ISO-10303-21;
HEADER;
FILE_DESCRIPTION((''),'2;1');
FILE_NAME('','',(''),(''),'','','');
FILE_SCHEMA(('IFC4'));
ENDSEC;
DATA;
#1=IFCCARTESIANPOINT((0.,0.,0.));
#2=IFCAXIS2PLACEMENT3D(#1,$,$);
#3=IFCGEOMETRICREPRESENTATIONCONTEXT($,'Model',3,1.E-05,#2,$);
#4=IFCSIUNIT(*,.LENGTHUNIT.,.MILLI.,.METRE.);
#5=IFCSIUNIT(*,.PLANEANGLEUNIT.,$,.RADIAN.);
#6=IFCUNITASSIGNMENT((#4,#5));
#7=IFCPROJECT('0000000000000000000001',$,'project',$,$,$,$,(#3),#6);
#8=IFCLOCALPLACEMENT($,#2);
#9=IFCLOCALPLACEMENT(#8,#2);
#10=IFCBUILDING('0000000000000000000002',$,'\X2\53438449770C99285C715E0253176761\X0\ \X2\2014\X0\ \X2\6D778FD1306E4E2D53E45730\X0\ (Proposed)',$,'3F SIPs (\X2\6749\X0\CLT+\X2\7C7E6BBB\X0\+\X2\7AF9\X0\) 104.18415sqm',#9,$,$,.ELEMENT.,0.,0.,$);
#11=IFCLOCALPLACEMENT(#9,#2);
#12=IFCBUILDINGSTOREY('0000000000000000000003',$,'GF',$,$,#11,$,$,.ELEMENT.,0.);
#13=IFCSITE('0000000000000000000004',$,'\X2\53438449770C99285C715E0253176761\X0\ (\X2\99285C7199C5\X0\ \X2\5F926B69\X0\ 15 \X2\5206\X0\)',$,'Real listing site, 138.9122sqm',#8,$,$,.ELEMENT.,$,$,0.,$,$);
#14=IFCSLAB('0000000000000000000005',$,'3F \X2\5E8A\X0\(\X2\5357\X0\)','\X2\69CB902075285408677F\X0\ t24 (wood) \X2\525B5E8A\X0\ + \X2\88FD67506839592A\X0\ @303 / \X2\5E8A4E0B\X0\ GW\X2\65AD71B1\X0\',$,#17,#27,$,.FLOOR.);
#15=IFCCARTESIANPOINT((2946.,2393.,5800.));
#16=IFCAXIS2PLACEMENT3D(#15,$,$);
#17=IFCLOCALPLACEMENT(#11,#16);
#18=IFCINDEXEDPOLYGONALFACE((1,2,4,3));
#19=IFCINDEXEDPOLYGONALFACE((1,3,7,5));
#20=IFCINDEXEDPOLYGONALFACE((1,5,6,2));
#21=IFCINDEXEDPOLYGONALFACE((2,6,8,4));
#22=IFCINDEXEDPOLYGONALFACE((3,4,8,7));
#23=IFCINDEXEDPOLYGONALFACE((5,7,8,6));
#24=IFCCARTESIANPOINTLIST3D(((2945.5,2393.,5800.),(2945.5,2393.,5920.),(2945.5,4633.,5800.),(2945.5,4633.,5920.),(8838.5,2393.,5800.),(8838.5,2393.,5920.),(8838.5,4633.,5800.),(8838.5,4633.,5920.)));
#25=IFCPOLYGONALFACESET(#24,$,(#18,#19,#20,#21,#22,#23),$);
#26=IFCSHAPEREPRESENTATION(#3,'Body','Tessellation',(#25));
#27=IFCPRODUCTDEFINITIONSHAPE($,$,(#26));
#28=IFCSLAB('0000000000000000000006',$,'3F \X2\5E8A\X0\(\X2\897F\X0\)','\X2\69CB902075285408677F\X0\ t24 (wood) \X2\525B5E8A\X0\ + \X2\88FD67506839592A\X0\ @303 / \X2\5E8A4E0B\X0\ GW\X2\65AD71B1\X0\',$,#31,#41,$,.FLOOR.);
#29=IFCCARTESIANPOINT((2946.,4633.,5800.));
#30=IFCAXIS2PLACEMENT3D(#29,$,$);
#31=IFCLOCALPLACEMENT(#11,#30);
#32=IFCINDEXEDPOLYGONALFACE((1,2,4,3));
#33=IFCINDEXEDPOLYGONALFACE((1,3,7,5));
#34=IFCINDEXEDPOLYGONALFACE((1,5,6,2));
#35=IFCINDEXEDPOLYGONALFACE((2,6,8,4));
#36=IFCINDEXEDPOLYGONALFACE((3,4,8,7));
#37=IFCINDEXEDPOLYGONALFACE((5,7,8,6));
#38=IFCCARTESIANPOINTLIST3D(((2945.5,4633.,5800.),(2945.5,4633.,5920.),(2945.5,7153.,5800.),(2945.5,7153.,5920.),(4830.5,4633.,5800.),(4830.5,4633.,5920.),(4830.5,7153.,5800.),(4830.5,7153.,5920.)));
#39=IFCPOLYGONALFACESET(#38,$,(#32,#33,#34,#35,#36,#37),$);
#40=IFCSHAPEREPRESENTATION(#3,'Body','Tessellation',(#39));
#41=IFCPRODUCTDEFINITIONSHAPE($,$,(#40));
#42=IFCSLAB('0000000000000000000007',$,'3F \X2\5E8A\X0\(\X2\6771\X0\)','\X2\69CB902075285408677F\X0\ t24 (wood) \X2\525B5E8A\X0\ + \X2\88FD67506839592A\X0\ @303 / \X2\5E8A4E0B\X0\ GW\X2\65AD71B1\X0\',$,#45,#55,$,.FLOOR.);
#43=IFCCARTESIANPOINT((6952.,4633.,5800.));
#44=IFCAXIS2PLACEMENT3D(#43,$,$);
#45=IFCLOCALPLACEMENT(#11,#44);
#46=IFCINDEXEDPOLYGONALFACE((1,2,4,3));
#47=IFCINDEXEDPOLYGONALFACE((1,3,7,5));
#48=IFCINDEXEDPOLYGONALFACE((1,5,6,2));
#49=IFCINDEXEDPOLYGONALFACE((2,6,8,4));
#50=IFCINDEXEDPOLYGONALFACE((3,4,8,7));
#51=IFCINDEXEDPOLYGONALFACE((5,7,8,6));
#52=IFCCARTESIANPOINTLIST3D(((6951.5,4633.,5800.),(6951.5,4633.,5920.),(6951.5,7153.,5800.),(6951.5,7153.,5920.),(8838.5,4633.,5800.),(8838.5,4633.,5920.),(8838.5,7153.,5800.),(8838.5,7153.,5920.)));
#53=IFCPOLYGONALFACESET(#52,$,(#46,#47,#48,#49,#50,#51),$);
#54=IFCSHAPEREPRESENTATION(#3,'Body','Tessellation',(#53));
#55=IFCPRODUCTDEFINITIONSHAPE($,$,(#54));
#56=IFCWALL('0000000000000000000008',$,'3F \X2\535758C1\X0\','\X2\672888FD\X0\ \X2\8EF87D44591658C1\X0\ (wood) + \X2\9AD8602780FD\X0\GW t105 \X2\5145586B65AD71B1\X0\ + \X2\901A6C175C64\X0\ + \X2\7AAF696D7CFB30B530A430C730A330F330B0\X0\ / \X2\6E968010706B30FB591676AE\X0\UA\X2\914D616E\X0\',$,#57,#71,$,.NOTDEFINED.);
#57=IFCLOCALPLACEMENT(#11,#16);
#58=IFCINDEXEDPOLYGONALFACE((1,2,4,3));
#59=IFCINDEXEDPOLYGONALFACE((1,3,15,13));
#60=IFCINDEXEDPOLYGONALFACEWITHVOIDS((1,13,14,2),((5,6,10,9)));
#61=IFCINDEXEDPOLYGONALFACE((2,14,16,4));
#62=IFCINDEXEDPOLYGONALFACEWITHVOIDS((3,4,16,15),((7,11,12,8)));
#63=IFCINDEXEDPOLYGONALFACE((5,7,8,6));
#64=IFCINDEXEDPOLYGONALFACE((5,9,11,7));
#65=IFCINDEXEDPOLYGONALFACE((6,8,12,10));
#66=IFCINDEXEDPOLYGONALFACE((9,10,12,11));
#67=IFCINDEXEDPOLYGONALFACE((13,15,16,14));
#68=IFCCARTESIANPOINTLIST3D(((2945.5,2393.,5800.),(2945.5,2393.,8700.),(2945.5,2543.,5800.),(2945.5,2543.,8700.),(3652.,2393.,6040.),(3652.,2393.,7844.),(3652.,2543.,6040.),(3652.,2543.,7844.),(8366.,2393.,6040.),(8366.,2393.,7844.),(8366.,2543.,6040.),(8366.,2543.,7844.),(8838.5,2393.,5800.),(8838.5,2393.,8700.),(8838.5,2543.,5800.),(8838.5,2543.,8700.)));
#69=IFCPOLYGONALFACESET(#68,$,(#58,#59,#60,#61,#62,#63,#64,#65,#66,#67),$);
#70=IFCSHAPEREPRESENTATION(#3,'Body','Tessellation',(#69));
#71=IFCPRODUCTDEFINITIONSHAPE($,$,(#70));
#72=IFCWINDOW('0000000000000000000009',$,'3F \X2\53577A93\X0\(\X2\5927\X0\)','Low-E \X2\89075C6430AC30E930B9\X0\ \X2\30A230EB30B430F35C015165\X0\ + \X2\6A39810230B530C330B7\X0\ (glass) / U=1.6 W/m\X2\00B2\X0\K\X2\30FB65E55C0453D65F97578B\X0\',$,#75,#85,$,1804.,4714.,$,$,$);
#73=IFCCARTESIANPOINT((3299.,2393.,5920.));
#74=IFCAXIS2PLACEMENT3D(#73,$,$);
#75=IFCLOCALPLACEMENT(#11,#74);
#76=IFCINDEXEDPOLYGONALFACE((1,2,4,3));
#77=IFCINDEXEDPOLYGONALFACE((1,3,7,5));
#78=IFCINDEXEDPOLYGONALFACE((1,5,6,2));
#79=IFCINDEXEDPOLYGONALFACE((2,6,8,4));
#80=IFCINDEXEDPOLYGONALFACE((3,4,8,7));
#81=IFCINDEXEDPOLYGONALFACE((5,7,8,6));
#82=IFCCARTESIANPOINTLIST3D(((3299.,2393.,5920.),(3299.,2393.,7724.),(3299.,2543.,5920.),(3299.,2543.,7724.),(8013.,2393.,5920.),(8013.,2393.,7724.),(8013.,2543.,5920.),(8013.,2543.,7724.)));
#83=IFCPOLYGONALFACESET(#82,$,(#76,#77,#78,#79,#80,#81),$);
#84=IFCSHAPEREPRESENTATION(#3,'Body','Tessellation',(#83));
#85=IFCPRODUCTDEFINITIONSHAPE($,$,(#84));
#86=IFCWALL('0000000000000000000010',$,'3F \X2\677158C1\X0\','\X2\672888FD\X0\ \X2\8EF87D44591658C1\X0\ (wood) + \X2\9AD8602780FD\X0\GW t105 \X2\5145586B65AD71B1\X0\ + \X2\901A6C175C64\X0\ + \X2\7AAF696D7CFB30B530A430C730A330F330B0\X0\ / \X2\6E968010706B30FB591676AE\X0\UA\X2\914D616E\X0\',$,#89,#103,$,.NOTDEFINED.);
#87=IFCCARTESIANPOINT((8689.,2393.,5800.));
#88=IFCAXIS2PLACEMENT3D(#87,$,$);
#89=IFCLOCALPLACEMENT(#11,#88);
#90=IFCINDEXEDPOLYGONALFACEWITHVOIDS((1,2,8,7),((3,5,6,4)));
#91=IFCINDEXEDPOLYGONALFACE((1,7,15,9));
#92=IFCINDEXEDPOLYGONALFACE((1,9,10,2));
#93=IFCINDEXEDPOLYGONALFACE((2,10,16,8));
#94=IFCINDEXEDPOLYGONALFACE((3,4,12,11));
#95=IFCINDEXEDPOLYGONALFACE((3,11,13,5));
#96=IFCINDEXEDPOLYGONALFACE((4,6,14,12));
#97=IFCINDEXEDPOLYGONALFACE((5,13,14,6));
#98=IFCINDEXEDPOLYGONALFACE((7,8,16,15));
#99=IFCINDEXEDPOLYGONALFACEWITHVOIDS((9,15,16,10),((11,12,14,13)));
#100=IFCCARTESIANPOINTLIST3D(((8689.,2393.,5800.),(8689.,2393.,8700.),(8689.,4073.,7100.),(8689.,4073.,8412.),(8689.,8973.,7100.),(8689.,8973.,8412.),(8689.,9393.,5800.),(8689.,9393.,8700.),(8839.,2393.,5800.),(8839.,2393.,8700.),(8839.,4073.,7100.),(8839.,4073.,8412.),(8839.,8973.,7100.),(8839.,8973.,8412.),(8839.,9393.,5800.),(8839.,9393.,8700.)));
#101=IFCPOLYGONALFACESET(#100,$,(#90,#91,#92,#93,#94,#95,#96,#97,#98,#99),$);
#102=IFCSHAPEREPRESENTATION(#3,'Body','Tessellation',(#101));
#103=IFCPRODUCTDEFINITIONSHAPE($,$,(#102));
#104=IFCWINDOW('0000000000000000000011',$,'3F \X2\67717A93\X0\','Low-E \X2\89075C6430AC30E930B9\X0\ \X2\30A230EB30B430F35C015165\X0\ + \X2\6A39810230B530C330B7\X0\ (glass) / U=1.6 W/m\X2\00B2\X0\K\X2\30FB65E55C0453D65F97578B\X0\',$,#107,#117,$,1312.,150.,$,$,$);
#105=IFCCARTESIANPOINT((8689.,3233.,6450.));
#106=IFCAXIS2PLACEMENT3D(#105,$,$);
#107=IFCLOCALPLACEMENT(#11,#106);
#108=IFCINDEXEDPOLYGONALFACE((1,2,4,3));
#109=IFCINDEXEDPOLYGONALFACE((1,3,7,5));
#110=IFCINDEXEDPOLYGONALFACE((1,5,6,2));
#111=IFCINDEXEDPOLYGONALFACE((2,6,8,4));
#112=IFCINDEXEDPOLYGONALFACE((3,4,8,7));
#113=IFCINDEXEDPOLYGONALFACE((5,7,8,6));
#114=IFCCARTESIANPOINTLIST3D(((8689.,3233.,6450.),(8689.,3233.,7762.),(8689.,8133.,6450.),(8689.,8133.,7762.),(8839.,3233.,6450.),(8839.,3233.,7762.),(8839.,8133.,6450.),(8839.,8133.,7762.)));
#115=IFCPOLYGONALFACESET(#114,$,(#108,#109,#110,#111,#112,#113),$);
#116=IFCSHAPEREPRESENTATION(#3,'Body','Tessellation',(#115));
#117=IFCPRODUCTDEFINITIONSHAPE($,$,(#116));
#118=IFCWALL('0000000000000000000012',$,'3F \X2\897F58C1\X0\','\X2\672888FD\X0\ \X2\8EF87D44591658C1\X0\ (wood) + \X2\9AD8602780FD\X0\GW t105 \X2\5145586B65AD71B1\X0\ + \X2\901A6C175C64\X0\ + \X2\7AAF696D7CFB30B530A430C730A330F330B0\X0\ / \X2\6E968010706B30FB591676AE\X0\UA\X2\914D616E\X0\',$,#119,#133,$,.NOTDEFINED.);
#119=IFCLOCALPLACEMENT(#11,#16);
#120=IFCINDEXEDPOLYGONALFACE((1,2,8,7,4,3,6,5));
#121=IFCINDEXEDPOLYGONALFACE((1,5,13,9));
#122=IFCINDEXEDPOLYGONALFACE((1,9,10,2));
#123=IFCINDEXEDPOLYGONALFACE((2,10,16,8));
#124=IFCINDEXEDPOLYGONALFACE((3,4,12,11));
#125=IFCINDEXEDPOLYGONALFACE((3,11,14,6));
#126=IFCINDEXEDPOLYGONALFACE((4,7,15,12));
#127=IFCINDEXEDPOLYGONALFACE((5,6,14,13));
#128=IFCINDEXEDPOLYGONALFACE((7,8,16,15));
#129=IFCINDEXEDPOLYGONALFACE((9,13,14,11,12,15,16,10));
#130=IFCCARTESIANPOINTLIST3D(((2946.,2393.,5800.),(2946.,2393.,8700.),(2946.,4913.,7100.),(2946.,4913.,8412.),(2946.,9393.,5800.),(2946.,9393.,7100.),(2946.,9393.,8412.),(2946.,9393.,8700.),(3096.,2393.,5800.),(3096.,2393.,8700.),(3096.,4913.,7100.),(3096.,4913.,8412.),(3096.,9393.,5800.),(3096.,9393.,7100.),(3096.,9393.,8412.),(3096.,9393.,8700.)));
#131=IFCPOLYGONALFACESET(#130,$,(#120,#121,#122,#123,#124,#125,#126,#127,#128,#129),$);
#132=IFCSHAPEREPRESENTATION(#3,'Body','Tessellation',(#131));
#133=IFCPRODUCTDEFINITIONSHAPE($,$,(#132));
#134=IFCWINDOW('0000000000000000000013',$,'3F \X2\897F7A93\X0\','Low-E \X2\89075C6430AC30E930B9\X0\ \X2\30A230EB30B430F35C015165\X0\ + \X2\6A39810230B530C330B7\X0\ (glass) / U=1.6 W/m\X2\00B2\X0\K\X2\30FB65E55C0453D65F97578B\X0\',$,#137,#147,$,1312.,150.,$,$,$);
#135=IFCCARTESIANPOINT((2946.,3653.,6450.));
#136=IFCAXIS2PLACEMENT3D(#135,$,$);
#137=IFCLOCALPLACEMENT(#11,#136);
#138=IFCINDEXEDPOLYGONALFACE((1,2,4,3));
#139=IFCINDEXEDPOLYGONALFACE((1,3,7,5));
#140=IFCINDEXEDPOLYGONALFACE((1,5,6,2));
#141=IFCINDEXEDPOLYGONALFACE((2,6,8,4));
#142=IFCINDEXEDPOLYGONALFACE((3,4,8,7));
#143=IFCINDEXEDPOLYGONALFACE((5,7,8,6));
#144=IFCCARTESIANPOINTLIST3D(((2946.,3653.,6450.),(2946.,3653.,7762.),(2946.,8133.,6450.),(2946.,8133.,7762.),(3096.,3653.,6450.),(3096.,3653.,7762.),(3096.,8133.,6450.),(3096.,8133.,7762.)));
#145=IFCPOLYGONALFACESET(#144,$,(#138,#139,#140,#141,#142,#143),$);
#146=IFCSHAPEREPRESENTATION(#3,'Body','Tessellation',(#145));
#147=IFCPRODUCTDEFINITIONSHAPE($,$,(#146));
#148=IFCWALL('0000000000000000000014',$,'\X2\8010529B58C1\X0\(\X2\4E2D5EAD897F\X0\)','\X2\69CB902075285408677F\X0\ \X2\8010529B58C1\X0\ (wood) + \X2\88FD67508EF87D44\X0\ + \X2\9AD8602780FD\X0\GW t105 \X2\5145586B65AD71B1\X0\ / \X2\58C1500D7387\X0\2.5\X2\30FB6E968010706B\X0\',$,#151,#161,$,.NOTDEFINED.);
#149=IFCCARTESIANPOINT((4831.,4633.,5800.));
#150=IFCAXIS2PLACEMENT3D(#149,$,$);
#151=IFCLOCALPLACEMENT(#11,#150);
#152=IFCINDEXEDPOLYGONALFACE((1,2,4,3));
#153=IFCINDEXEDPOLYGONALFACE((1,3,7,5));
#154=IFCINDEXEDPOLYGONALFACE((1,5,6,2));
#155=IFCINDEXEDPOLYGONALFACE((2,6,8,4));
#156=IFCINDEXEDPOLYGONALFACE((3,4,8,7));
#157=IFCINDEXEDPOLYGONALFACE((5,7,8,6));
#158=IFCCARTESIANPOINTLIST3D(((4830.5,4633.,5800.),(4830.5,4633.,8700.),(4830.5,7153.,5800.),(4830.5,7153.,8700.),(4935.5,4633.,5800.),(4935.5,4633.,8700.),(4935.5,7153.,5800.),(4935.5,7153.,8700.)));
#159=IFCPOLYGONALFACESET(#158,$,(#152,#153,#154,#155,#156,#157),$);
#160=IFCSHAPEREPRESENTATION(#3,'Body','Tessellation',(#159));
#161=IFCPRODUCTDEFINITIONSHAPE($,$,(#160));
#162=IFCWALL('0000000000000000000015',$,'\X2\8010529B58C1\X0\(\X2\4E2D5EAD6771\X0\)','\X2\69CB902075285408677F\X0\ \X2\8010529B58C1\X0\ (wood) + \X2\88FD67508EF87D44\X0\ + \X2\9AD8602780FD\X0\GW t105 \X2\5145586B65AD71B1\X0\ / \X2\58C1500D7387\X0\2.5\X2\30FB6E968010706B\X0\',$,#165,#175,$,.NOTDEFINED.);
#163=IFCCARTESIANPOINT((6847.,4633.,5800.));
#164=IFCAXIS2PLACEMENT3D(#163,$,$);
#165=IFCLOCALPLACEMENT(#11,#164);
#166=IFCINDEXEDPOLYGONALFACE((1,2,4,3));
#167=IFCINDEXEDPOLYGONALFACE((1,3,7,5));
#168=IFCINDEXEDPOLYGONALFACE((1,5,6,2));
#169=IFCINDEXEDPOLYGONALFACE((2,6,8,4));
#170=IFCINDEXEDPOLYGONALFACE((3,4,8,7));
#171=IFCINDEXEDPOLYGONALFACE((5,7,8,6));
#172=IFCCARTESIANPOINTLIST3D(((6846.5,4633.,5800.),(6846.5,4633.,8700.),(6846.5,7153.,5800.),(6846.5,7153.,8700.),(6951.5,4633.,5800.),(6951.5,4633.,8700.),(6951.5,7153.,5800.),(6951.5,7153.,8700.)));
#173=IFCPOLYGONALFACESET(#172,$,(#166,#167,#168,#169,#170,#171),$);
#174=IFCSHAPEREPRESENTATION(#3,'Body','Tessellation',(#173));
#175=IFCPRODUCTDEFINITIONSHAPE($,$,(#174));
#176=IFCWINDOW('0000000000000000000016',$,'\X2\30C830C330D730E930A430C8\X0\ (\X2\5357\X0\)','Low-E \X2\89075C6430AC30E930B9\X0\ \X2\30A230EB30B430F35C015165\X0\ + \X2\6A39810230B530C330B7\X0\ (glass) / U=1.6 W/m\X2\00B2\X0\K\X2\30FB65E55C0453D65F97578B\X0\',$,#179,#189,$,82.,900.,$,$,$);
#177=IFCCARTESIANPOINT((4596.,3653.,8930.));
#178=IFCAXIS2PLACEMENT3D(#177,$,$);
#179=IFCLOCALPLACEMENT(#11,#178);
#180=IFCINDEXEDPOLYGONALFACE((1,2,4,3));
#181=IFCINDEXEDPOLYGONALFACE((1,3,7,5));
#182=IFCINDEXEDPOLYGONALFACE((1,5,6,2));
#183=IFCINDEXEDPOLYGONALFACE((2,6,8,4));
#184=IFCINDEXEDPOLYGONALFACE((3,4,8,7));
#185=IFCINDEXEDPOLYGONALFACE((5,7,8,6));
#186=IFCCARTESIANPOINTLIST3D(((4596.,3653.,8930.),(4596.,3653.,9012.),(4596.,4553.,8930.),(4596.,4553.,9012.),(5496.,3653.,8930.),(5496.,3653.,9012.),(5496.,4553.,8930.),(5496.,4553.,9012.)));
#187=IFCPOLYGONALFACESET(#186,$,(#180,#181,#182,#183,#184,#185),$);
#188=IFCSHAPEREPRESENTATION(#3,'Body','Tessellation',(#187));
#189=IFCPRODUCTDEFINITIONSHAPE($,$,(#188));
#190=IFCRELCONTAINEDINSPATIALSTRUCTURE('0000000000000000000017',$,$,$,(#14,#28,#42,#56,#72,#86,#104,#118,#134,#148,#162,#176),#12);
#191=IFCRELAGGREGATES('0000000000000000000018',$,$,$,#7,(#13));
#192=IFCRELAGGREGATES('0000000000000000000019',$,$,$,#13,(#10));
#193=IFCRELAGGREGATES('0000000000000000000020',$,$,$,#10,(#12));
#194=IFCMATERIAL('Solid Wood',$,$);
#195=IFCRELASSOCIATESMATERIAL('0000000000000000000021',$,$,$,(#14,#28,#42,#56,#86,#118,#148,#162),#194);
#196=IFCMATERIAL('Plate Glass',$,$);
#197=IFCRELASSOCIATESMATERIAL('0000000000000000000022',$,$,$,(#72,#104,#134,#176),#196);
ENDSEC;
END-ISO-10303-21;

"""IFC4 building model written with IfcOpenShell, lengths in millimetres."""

from ifc_helpers import new_model, si_unit, frame, frame_2d, origin, place, context, project, spatial, rectangle, extrude, material, element, fill, save


model = new_model("IFC4")

# Units and contexts
model_context = context("Model", 3, precision=1e-05, world=origin())
ifc_project = project(units=[si_unit("LENGTHUNIT", "METRE", prefix="MILLI"), si_unit("PLANEANGLEUNIT", "RADIAN")], contexts=[model_context])

# Site, building, storey
site_placement = place(None, origin())
site = spatial("IfcSite", under=ifc_project, at=site_placement, Name="千葉県館山市北条 (館山駅 徒歩 15 分)", ObjectType="Real listing site, 138.9122sqm", CompositionType="ELEMENT", RefElevation=0.0)
building_placement = place(site_placement, origin())
building = spatial("IfcBuilding", under=site, at=building_placement, Name="千葉県館山市北条 — 海近の中古地 (Proposed)", ObjectType="3F SIPs (杉CLT+籾殻+竹) 104.18415sqm", CompositionType="ELEMENT", ElevationOfRefHeight=0.0, ElevationOfTerrain=0.0)
storey_placement = place(building_placement, origin())
storey = spatial("IfcBuildingStorey", under=building, at=storey_placement, Name="GF", CompositionType="ELEMENT", Elevation=0.0)

# Slabs
ifc_material_1 = material(Name="Solid Wood")
slab_1_placement = place(storey_placement, frame((2946.0, 2393.0, 5800.0)))
element("IfcSlab", 1, at=slab_1_placement, inside=storey, material=ifc_material_1, Name="3F 床(南)", Description="構造用合板 t24 (wood) 剛床 + 製材根太 @303 / 床下 GW断熱", PredefinedType="FLOOR", context=model_context, shape_type="SweptSolid", body=[
    extrude(rectangle(XDim=5893.0, YDim=2240.0, at=frame_2d((2946.0, 1120.0))), frame((2946.0, 2393.0, 5800.0)), (0.0, 0.0, 1.0), 120.0),
])
slab_2_placement = place(storey_placement, frame((2946.0, 4633.0, 5800.0)))
element("IfcSlab", 2, at=slab_2_placement, inside=storey, material=ifc_material_1, Name="3F 床(西)", Description="構造用合板 t24 (wood) 剛床 + 製材根太 @303 / 床下 GW断熱", PredefinedType="FLOOR", context=model_context, shape_type="SweptSolid", body=[
    extrude(rectangle(XDim=1885.0, YDim=2520.0, at=frame_2d((942.0, 1260.0))), frame((2946.0, 4633.0, 5800.0)), (0.0, 0.0, 1.0), 120.0),
])
slab_3_placement = place(storey_placement, frame((6952.0, 4633.0, 5800.0)))
element("IfcSlab", 3, at=slab_3_placement, inside=storey, material=ifc_material_1, Name="3F 床(東)", Description="構造用合板 t24 (wood) 剛床 + 製材根太 @303 / 床下 GW断熱", PredefinedType="FLOOR", context=model_context, shape_type="SweptSolid", body=[
    extrude(rectangle(XDim=1887.0, YDim=2520.0, at=frame_2d((943.0, 1260.0))), frame((6952.0, 4633.0, 5800.0)), (0.0, 0.0, 1.0), 120.0),
])

# Walls, openings, windows
wall_1_placement = place(storey_placement, frame((2946.0, 2393.0, 5800.0)))
wall_1 = element("IfcWall", 4, at=wall_1_placement, inside=storey, material=ifc_material_1, Name="3F 南壁", Description="木製 軸組外壁 (wood) + 高性能GW t105 充填断熱 + 通気層 + 窯業系サイディング / 準耐火・外皮UA配慮", PredefinedType="NOTDEFINED", context=model_context, shape_type="SweptSolid", body=[
    extrude(rectangle(XDim=5893.0, YDim=150.0, at=frame_2d((2946.0, 75.0))), frame((2946.0, 2393.0, 5800.0)), (0.0, 0.0, 1.0), 2900.0),
])
opening_1_placement = place(storey_placement, frame((3299.0, 2393.0, 5920.0)))
opening_1 = element("IfcOpeningElement", 5, at=opening_1_placement, cuts=wall_1, PredefinedType="NOTDEFINED", context=model_context, shape_type="SweptSolid", body=[
    extrude(rectangle(XDim=4714.0, YDim=150.0, at=frame_2d((2357.0, 75.0))), frame((3299.0, 2393.0, 5920.0)), (0.0, 0.0, 1.0), 1804.0),
])
ifc_material_2 = material(Name="Plate Glass")
window_1_placement = place(storey_placement, frame((3299.0, 2393.0, 5920.0)))
window_1 = element("IfcWindow", 6, at=window_1_placement, inside=storey, material=ifc_material_2, Name="3F 南窓(大)", Description="Low-E 複層ガラス アルゴン封入 + 樹脂サッシ (glass) / U=1.6 W/m²K・日射取得型", OverallHeight=1804.0, OverallWidth=4714.0, context=model_context, shape_type="SweptSolid", body=[
    extrude(rectangle(XDim=4714.0, YDim=150.0, at=frame_2d((2357.0, 75.0))), frame((3299.0, 2393.0, 5920.0)), (0.0, 0.0, 1.0), 1804.0),
])
fill(opening_1, window_1)
wall_2_placement = place(storey_placement, frame((8689.0, 2393.0, 5800.0)))
wall_2 = element("IfcWall", 7, at=wall_2_placement, inside=storey, material=ifc_material_1, Name="3F 東壁", Description="木製 軸組外壁 (wood) + 高性能GW t105 充填断熱 + 通気層 + 窯業系サイディング / 準耐火・外皮UA配慮", PredefinedType="NOTDEFINED", context=model_context, shape_type="SweptSolid", body=[
    extrude(rectangle(XDim=150.0, YDim=7000.0, at=frame_2d((75.0, 3500.0))), frame((8689.0, 2393.0, 5800.0)), (0.0, 0.0, 1.0), 2900.0),
])
opening_2_placement = place(storey_placement, frame((8689.0, 3233.0, 6450.0)))
opening_2 = element("IfcOpeningElement", 8, at=opening_2_placement, cuts=wall_2, PredefinedType="NOTDEFINED", context=model_context, shape_type="SweptSolid", body=[
    extrude(rectangle(XDim=150.0, YDim=4900.0, at=frame_2d((75.0, 2450.0))), frame((8689.0, 3233.0, 6450.0)), (0.0, 0.0, 1.0), 1312.0),
])
window_2_placement = place(storey_placement, frame((8689.0, 3233.0, 6450.0)))
window_2 = element("IfcWindow", 9, at=window_2_placement, inside=storey, material=ifc_material_2, Name="3F 東窓", Description="Low-E 複層ガラス アルゴン封入 + 樹脂サッシ (glass) / U=1.6 W/m²K・日射取得型", OverallHeight=1312.0, OverallWidth=150.0, context=model_context, shape_type="SweptSolid", body=[
    extrude(rectangle(XDim=150.0, YDim=4900.0, at=frame_2d((75.0, 2450.0))), frame((8689.0, 3233.0, 6450.0)), (0.0, 0.0, 1.0), 1312.0),
])
fill(opening_2, window_2)
wall_3_placement = place(storey_placement, frame((2946.0, 2393.0, 5800.0)))
wall_3 = element("IfcWall", 10, at=wall_3_placement, inside=storey, material=ifc_material_1, Name="3F 西壁", Description="木製 軸組外壁 (wood) + 高性能GW t105 充填断熱 + 通気層 + 窯業系サイディング / 準耐火・外皮UA配慮", PredefinedType="NOTDEFINED", context=model_context, shape_type="SweptSolid", body=[
    extrude(rectangle(XDim=150.0, YDim=7000.0, at=frame_2d((75.0, 3500.0))), frame((2946.0, 2393.0, 5800.0)), (0.0, 0.0, 1.0), 2900.0),
])
opening_3_placement = place(storey_placement, frame((2946.0, 3653.0, 6450.0)))
opening_3 = element("IfcOpeningElement", 11, at=opening_3_placement, cuts=wall_3, PredefinedType="NOTDEFINED", context=model_context, shape_type="SweptSolid", body=[
    extrude(rectangle(XDim=150.0, YDim=4480.0, at=frame_2d((75.0, 2240.0))), frame((2946.0, 3653.0, 6450.0)), (0.0, 0.0, 1.0), 1312.0),
])
window_3_placement = place(storey_placement, frame((2946.0, 3653.0, 6450.0)))
window_3 = element("IfcWindow", 12, at=window_3_placement, inside=storey, material=ifc_material_2, Name="3F 西窓", Description="Low-E 複層ガラス アルゴン封入 + 樹脂サッシ (glass) / U=1.6 W/m²K・日射取得型", OverallHeight=1312.0, OverallWidth=150.0, context=model_context, shape_type="SweptSolid", body=[
    extrude(rectangle(XDim=150.0, YDim=4480.0, at=frame_2d((75.0, 2240.0))), frame((2946.0, 3653.0, 6450.0)), (0.0, 0.0, 1.0), 1312.0),
])
fill(opening_3, window_3)

# Walls
wall_4_placement = place(storey_placement, frame((4831.0, 4633.0, 5800.0)))
element("IfcWall", 13, at=wall_4_placement, inside=storey, material=ifc_material_1, Name="耐力壁(中庭西)", Description="構造用合板 耐力壁 (wood) + 製材軸組 + 高性能GW t105 充填断熱 / 壁倍率2.5・準耐火", PredefinedType="NOTDEFINED", context=model_context, shape_type="SweptSolid", body=[
    extrude(rectangle(XDim=105.0, YDim=2520.0, at=frame_2d((52.0, 1260.0))), frame((4831.0, 4633.0, 5800.0)), (0.0, 0.0, 1.0), 2900.0),
])
wall_5_placement = place(storey_placement, frame((6847.0, 4633.0, 5800.0)))
element("IfcWall", 14, at=wall_5_placement, inside=storey, material=ifc_material_1, Name="耐力壁(中庭東)", Description="構造用合板 耐力壁 (wood) + 製材軸組 + 高性能GW t105 充填断熱 / 壁倍率2.5・準耐火", PredefinedType="NOTDEFINED", context=model_context, shape_type="SweptSolid", body=[
    extrude(rectangle(XDim=105.0, YDim=2520.0, at=frame_2d((52.0, 1260.0))), frame((6847.0, 4633.0, 5800.0)), (0.0, 0.0, 1.0), 2900.0),
])

# Window
window_4_placement = place(storey_placement, frame((4596.0, 3653.0, 8930.0)))
element("IfcWindow", 15, at=window_4_placement, inside=storey, material=ifc_material_2, Name="トップライト (南)", Description="Low-E 複層ガラス アルゴン封入 + 樹脂サッシ (glass) / U=1.6 W/m²K・日射取得型", OverallHeight=82.0, OverallWidth=900.0, context=model_context, shape_type="SweptSolid", body=[
    extrude(rectangle(XDim=900.0, YDim=900.0, at=frame_2d((450.0, 450.0))), frame((4596.0, 3653.0, 8930.0)), (0.0, 0.0, 1.0), 82.0),
])

save(model, "model.ifc")
